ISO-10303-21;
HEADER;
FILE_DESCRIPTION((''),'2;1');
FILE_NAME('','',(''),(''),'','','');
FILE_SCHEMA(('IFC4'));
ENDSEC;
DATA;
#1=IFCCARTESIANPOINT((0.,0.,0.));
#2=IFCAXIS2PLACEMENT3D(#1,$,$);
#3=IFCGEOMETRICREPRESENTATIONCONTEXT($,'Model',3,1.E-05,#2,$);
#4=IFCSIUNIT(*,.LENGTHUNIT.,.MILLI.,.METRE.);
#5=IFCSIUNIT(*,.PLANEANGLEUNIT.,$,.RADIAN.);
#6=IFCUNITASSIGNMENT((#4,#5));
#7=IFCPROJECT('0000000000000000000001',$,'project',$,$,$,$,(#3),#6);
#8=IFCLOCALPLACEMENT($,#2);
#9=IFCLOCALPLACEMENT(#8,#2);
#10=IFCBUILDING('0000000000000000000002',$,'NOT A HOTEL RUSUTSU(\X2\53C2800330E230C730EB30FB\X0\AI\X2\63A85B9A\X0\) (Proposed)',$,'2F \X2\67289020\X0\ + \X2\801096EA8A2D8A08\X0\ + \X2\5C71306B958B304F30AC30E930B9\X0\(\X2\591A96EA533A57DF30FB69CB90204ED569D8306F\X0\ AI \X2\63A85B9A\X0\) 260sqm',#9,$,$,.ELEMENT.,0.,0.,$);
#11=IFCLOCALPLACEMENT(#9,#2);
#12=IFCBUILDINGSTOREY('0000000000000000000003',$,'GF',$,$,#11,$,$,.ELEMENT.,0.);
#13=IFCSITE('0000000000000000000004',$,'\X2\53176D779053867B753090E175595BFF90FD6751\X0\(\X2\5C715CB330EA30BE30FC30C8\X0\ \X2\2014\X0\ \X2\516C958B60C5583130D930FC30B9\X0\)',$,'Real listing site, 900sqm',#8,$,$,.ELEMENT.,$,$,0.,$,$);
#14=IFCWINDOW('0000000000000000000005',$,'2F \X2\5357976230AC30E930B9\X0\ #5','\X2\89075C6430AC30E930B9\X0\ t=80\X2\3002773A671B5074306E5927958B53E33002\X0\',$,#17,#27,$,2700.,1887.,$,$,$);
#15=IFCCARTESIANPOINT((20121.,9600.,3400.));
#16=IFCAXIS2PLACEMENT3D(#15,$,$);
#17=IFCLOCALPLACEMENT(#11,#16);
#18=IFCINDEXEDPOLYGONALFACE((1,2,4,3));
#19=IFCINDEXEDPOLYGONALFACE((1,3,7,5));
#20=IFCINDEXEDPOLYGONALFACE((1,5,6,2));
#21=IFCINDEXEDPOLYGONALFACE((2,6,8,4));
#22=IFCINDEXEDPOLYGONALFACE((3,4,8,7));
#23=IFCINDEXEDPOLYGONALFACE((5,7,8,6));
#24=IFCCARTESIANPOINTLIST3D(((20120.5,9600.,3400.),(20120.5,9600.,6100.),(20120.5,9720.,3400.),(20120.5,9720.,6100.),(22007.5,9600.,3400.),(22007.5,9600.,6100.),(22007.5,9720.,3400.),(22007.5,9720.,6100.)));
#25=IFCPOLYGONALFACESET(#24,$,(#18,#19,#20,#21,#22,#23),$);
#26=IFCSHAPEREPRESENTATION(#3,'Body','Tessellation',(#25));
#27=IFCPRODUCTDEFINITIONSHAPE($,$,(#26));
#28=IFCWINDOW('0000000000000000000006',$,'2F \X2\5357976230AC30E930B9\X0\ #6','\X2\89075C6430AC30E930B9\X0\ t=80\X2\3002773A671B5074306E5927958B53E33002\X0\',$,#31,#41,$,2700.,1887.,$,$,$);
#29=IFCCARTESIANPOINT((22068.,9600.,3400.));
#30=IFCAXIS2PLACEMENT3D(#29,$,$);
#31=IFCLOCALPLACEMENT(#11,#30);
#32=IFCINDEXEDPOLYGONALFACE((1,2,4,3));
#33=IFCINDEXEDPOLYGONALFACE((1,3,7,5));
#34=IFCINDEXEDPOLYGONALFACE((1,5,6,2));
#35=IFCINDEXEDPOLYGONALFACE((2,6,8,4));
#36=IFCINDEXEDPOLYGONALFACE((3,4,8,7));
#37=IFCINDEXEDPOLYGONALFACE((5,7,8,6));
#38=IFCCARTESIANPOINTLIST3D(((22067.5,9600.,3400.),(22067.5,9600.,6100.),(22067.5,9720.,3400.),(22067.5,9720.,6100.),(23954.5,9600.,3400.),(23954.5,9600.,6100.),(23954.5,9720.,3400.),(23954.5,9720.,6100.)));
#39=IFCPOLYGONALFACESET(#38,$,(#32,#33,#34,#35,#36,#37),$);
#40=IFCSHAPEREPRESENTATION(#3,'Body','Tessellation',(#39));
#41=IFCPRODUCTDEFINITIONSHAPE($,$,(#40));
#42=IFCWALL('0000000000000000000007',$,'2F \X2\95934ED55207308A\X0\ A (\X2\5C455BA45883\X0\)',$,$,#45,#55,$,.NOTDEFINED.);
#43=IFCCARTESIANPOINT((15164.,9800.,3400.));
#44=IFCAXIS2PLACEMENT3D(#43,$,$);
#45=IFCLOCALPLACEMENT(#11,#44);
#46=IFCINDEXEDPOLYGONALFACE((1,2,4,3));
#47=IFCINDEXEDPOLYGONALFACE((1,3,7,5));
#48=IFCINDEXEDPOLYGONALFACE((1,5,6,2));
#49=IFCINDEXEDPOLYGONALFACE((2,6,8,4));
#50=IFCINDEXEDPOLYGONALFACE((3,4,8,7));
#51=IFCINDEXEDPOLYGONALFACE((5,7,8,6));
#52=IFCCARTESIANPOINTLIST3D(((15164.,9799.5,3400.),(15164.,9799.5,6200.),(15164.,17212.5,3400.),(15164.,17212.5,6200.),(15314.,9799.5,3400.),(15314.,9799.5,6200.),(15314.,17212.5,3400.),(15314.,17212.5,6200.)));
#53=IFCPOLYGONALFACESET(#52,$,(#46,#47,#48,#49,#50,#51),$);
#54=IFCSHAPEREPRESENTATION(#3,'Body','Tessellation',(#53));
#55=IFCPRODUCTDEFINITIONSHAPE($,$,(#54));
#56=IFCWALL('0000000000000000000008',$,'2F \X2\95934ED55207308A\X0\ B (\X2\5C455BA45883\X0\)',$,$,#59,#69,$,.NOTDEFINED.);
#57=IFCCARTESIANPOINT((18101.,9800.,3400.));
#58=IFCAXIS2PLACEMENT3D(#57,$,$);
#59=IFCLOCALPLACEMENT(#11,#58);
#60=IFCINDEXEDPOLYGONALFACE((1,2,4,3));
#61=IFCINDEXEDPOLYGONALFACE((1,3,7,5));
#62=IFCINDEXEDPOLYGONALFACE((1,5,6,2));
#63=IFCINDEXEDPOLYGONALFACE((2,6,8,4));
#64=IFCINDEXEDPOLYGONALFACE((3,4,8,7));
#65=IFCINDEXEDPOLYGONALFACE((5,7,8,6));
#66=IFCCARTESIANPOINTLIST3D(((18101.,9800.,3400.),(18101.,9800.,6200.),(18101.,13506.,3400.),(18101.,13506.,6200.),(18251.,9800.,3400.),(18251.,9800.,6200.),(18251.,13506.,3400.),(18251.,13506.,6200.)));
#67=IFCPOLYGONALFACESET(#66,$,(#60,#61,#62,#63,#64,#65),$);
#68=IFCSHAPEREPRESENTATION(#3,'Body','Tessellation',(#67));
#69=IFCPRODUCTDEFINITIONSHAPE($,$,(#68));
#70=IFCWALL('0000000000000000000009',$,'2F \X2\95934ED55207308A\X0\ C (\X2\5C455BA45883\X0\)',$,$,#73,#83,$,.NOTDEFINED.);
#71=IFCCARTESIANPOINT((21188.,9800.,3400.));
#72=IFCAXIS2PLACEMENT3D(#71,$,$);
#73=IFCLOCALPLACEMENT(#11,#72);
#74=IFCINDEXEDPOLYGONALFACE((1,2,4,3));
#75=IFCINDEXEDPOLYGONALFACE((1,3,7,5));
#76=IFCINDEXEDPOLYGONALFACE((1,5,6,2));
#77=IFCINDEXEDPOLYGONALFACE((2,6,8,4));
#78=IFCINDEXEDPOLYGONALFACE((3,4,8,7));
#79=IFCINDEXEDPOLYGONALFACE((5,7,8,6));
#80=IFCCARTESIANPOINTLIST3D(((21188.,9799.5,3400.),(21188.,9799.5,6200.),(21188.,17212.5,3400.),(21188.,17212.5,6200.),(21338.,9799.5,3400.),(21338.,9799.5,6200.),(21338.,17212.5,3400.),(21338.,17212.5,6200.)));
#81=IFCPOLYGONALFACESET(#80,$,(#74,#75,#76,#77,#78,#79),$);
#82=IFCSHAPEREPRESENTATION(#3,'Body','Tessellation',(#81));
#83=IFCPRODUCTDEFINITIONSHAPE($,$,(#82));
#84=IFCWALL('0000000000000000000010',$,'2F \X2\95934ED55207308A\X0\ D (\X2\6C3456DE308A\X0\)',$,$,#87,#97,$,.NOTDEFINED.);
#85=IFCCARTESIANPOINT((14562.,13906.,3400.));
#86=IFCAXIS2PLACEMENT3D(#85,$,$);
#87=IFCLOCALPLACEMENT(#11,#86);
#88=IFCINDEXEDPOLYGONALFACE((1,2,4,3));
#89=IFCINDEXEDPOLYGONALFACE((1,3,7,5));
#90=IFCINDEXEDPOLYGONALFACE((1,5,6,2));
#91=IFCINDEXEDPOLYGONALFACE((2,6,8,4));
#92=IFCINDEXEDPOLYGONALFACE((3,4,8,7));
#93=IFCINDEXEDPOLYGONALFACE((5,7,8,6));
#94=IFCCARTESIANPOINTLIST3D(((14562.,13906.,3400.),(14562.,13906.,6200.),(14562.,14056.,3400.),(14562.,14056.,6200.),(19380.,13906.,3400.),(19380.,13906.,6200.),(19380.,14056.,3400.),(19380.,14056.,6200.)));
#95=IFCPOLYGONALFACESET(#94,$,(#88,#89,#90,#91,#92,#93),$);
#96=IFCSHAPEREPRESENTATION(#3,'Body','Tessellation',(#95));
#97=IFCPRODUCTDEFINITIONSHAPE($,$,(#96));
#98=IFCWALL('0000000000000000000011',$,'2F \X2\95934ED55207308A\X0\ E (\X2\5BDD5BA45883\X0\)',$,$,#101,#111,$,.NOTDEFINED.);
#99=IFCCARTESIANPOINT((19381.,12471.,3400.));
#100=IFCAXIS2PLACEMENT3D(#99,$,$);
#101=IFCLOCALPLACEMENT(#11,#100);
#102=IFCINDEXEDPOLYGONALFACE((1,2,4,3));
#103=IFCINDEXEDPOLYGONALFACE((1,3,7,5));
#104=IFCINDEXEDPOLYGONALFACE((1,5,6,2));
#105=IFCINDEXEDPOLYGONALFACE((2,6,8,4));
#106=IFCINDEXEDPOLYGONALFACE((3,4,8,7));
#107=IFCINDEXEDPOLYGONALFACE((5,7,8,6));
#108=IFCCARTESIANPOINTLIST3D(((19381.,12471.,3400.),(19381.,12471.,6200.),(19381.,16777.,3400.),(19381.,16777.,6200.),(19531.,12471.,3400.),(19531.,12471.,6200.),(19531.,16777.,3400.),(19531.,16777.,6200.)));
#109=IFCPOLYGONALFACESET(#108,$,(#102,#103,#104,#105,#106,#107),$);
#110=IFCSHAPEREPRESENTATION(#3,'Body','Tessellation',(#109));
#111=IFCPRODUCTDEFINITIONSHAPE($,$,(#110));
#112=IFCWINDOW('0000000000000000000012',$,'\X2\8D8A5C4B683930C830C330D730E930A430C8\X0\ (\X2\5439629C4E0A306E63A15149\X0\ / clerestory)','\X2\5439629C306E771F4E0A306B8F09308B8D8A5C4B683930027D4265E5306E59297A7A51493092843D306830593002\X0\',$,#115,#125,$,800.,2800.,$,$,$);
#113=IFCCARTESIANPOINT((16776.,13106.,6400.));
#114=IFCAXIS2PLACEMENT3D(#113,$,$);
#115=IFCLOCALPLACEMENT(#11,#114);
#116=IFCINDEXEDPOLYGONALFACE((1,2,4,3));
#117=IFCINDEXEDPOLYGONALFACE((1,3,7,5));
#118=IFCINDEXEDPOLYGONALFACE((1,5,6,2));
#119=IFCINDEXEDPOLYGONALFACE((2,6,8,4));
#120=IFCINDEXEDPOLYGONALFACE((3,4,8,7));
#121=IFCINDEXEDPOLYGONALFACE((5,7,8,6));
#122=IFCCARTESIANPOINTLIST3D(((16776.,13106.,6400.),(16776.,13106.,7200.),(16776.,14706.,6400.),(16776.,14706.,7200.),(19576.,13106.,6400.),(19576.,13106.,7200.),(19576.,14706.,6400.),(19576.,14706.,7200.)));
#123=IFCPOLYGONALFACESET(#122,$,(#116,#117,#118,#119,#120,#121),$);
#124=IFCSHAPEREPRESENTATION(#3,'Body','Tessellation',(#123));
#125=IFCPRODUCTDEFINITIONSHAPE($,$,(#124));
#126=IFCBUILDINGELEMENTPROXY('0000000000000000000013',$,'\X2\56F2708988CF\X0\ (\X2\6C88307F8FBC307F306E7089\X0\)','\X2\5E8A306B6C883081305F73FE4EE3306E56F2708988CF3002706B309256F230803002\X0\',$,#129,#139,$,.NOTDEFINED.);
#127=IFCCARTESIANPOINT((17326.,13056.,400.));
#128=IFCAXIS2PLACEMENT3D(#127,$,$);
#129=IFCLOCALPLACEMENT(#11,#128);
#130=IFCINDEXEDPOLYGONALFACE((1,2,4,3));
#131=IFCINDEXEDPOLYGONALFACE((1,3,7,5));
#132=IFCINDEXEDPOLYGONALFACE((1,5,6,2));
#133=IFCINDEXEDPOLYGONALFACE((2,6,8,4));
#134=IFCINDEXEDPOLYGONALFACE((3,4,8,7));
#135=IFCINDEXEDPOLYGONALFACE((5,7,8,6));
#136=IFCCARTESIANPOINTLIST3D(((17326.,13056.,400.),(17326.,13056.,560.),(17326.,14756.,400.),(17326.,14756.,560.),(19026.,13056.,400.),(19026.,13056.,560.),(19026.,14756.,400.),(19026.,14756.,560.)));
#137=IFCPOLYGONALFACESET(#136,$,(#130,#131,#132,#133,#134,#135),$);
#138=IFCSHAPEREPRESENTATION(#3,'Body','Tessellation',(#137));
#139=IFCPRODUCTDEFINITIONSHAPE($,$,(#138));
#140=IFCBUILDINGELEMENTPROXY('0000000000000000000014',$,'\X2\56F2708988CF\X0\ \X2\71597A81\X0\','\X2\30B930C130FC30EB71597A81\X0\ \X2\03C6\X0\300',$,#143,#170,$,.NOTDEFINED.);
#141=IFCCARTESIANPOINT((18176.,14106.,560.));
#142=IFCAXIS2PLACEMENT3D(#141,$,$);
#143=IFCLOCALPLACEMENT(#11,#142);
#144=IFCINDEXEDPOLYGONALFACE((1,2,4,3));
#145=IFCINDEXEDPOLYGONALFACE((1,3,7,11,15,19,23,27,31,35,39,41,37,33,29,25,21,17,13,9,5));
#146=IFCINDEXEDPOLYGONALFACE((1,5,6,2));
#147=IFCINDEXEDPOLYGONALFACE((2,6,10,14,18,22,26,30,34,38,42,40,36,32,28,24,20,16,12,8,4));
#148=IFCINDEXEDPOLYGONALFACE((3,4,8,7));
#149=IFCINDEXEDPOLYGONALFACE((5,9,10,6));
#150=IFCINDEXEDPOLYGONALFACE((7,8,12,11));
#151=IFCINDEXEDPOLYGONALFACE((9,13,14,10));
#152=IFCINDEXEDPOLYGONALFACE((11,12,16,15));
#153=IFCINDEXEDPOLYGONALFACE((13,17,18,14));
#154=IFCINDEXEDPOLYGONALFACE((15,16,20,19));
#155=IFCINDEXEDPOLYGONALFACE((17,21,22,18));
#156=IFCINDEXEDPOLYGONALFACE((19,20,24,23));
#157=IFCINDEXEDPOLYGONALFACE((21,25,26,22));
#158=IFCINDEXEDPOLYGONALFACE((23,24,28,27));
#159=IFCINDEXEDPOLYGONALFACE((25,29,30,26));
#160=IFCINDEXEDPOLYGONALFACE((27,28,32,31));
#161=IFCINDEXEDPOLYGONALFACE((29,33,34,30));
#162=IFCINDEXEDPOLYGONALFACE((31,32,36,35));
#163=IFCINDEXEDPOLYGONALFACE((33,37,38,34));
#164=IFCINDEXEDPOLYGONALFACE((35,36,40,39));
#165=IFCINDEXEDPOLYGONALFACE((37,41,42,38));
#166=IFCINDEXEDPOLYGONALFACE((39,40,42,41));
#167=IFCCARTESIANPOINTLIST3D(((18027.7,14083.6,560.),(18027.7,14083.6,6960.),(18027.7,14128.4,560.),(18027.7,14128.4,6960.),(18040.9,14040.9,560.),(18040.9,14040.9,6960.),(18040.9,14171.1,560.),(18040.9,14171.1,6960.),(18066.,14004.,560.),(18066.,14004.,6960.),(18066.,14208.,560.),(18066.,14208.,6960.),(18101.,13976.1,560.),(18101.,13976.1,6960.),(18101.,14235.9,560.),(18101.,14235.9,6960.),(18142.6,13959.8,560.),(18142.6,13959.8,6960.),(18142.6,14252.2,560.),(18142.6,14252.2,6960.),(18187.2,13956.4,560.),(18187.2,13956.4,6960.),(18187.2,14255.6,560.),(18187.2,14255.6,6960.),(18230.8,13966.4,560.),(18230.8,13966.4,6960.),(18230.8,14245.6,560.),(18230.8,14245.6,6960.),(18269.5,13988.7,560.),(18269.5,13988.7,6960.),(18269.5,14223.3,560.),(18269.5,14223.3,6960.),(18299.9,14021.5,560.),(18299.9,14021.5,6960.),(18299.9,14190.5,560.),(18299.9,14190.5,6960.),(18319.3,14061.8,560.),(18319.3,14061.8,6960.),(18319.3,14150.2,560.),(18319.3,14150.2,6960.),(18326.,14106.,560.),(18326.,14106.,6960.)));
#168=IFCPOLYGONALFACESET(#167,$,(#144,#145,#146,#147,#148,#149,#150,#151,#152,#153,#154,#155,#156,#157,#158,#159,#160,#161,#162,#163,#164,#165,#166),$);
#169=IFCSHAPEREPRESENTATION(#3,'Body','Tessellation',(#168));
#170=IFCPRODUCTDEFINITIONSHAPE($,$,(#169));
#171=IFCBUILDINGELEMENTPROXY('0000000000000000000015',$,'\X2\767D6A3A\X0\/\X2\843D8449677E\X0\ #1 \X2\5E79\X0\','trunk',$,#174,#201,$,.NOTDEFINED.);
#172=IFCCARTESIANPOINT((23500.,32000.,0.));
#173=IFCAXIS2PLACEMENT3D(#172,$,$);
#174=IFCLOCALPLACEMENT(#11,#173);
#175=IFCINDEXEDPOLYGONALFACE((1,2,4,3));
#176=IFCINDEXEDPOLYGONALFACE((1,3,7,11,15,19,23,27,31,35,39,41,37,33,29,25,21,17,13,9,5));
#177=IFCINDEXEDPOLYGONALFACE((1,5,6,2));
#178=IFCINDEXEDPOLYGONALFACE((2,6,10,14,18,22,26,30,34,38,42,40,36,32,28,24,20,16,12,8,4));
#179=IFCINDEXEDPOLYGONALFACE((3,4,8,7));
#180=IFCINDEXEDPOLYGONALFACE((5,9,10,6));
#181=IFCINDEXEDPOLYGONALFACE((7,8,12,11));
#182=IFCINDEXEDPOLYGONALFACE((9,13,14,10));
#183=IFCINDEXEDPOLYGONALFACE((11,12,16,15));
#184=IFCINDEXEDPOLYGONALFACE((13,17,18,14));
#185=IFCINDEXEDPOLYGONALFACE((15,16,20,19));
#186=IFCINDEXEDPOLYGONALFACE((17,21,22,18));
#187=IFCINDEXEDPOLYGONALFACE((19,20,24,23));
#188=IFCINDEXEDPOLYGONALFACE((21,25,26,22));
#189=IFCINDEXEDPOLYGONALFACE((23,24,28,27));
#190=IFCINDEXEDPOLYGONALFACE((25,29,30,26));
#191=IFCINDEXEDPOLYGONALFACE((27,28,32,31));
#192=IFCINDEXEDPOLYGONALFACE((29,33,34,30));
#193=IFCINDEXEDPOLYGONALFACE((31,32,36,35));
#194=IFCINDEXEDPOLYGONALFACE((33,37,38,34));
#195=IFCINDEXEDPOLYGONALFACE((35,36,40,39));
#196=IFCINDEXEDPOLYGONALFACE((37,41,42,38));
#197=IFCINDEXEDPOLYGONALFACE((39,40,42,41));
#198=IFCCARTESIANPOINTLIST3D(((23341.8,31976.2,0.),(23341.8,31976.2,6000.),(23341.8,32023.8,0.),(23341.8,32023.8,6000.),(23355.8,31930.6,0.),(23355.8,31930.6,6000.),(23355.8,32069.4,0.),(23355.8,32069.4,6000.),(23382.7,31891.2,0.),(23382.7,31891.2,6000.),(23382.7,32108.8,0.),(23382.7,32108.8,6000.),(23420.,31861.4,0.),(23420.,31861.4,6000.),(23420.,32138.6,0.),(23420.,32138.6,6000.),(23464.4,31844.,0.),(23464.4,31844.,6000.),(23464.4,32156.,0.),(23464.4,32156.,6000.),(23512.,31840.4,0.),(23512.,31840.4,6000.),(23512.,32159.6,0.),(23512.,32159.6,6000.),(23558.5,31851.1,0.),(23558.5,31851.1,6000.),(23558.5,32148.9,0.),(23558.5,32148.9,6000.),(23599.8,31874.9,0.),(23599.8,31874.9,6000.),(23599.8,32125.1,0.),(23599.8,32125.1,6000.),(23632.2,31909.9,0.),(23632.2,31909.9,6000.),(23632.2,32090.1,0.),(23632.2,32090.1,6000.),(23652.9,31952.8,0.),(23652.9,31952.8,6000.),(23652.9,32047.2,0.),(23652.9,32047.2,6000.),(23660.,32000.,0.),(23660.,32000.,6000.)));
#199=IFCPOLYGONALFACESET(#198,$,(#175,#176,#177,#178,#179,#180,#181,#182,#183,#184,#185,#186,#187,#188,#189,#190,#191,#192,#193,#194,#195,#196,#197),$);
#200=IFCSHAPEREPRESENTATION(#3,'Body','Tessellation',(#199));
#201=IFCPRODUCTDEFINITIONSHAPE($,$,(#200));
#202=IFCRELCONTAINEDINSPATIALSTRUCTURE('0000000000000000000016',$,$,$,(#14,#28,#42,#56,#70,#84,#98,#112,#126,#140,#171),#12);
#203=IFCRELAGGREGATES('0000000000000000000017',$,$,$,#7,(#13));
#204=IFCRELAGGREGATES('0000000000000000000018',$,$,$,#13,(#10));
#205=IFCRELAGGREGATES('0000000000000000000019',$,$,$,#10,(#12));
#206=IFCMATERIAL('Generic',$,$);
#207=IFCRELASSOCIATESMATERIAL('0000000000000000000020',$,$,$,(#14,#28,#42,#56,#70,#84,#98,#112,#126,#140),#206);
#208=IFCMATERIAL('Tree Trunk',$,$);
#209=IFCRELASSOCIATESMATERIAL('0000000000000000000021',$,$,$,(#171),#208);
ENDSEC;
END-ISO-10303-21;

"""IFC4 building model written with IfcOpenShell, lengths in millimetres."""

from ifc_helpers import new_model, si_unit, frame, frame_2d, origin, origin_2d, place, context, project, spatial, rectangle, circle, extrude, material, element, save


model = new_model("IFC4")

# Units and contexts
model_context = context("Model", 3, precision=1e-05, world=origin())
ifc_project = project(units=[si_unit("LENGTHUNIT", "METRE", prefix="MILLI"), si_unit("PLANEANGLEUNIT", "RADIAN")], contexts=[model_context])

# Site, building, storey
site_placement = place(None, origin())
site = spatial("IfcSite", under=ifc_project, at=site_placement, Name="北海道虻田郡留寿都村(山岳リゾート — 公開情報ベース)", ObjectType="Real listing site, 900sqm", CompositionType="ELEMENT", RefElevation=0.0)
building_placement = place(site_placement, origin())
building = spatial("IfcBuilding", under=site, at=building_placement, Name="NOT A HOTEL RUSUTSU(参考モデル・AI推定) (Proposed)", ObjectType="2F 木造 + 耐雪設計 + 山に開くガラス(多雪区域・構造仕様は AI 推定) 260sqm", CompositionType="ELEMENT", ElevationOfRefHeight=0.0, ElevationOfTerrain=0.0)
storey_placement = place(building_placement, origin())
storey = spatial("IfcBuildingStorey", under=building, at=storey_placement, Name="GF", CompositionType="ELEMENT", Elevation=0.0)

# Shared definitions
ifc_material_1 = material(Name="Generic")

# Windows
window_1_placement = place(storey_placement, frame((20121.0, 9600.0, 3400.0)))
element("IfcWindow", 1, at=window_1_placement, inside=storey, material=ifc_material_1, Name="2F 南面ガラス #5", Description="複層ガラス t=80。眺望側の大開口。", OverallHeight=2700.0, OverallWidth=1887.0, context=model_context, shape_type="SweptSolid", body=[
    extrude(rectangle(XDim=1887.0, YDim=120.0, at=frame_2d((943.0, 60.0))), frame((20121.0, 9600.0, 3400.0)), (0.0, 0.0, 1.0), 2700.0),
])
window_2_placement = place(storey_placement, frame((22068.0, 9600.0, 3400.0)))
element("IfcWindow", 2, at=window_2_placement, inside=storey, material=ifc_material_1, Name="2F 南面ガラス #6", Description="複層ガラス t=80。眺望側の大開口。", OverallHeight=2700.0, OverallWidth=1887.0, context=model_context, shape_type="SweptSolid", body=[
    extrude(rectangle(XDim=1887.0, YDim=120.0, at=frame_2d((943.0, 60.0))), frame((22068.0, 9600.0, 3400.0)), (0.0, 0.0, 1.0), 2700.0),
])

# Walls
wall_1_placement = place(storey_placement, frame((15164.0, 9800.0, 3400.0)))
element("IfcWall", 3, at=wall_1_placement, inside=storey, material=ifc_material_1, Name="2F 間仕切り A (居室境)", PredefinedType="NOTDEFINED", context=model_context, shape_type="SweptSolid", body=[
    extrude(rectangle(XDim=150.0, YDim=7413.0, at=frame_2d((75.0, 3706.0))), frame((15164.0, 9800.0, 3400.0)), (0.0, 0.0, 1.0), 2800.0),
])
wall_2_placement = place(storey_placement, frame((18101.0, 9800.0, 3400.0)))
element("IfcWall", 4, at=wall_2_placement, inside=storey, material=ifc_material_1, Name="2F 間仕切り B (居室境)", PredefinedType="NOTDEFINED", context=model_context, shape_type="SweptSolid", body=[
    extrude(rectangle(XDim=150.0, YDim=3706.0, at=frame_2d((75.0, 1853.0))), frame((18101.0, 9800.0, 3400.0)), (0.0, 0.0, 1.0), 2800.0),
])
wall_3_placement = place(storey_placement, frame((21188.0, 9800.0, 3400.0)))
element("IfcWall", 5, at=wall_3_placement, inside=storey, material=ifc_material_1, Name="2F 間仕切り C (居室境)", PredefinedType="NOTDEFINED", context=model_context, shape_type="SweptSolid", body=[
    extrude(rectangle(XDim=150.0, YDim=7413.0, at=frame_2d((75.0, 3706.0))), frame((21188.0, 9800.0, 3400.0)), (0.0, 0.0, 1.0), 2800.0),
])
wall_4_placement = place(storey_placement, frame((14562.0, 13906.0, 3400.0)))
element("IfcWall", 6, at=wall_4_placement, inside=storey, material=ifc_material_1, Name="2F 間仕切り D (水回り)", PredefinedType="NOTDEFINED", context=model_context, shape_type="SweptSolid", body=[
    extrude(rectangle(XDim=4818.0, YDim=150.0, at=frame_2d((2409.0, 75.0))), frame((14562.0, 13906.0, 3400.0)), (0.0, 0.0, 1.0), 2800.0),
])
wall_5_placement = place(storey_placement, frame((19381.0, 12471.0, 3400.0)))
element("IfcWall", 7, at=wall_5_placement, inside=storey, material=ifc_material_1, Name="2F 間仕切り E (寝室境)", PredefinedType="NOTDEFINED", context=model_context, shape_type="SweptSolid", body=[
    extrude(rectangle(XDim=150.0, YDim=4306.0, at=frame_2d((75.0, 2153.0))), frame((19381.0, 12471.0, 3400.0)), (0.0, 0.0, 1.0), 2800.0),
])

# Window
window_3_placement = place(storey_placement, frame((16776.0, 13106.0, 6400.0)))
element("IfcWindow", 8, at=window_3_placement, inside=storey, material=ifc_material_1, Name="越屋根トップライト (吹抜上の採光 / clerestory)", Description="吹抜の真上に載る越屋根。終日の天空光を落とす。", OverallHeight=800.0, OverallWidth=2800.0, context=model_context, shape_type="SweptSolid", body=[
    extrude(rectangle(XDim=2800.0, YDim=1600.0, at=frame_2d((1400.0, 800.0))), frame((16776.0, 13106.0, 6400.0)), (0.0, 0.0, 1.0), 800.0),
])

# Building element proxies
proxy_1_placement = place(storey_placement, frame((17326.0, 13056.0, 400.0)))
element("IfcBuildingElementProxy", 9, at=proxy_1_placement, inside=storey, material=ifc_material_1, Name="囲炉裏 (沈み込みの炉)", Description="床に沈めた現代の囲炉裏。火を囲む。", PredefinedType="NOTDEFINED", context=model_context, shape_type="SweptSolid", body=[
    extrude(rectangle(XDim=1700.0, YDim=1700.0, at=frame_2d((850.0, 850.0))), frame((17326.0, 13056.0, 400.0)), (0.0, 0.0, 1.0), 160.0),
])
proxy_2_placement = place(storey_placement, frame((18176.0, 14106.0, 560.0)))
element("IfcBuildingElementProxy", 10, at=proxy_2_placement, inside=storey, material=ifc_material_1, Name="囲炉裏 煙突", Description="スチール煙突 φ300", PredefinedType="NOTDEFINED", context=model_context, shape_type="SweptSolid", body=[
    extrude(circle(Radius=150.0, at=origin_2d()), frame((18176.0, 14106.0, 560.0)), (0.0, 0.0, 1.0), 6400.0),
])
ifc_material_2 = material(Name="Tree Trunk")
proxy_3_placement = place(storey_placement, frame((23500.0, 32000.0, 0.0)))
element("IfcBuildingElementProxy", 11, at=proxy_3_placement, inside=storey, material=ifc_material_2, Name="白樺/落葉松 #1 幹", Description="trunk", PredefinedType="NOTDEFINED", context=model_context, shape_type="SweptSolid", body=[
    extrude(circle(Radius=160.0, at=origin_2d()), frame((23500.0, 32000.0, 0.0)), (0.0, 0.0, 1.0), 6000.0),
])

save(model, "model.ifc")
